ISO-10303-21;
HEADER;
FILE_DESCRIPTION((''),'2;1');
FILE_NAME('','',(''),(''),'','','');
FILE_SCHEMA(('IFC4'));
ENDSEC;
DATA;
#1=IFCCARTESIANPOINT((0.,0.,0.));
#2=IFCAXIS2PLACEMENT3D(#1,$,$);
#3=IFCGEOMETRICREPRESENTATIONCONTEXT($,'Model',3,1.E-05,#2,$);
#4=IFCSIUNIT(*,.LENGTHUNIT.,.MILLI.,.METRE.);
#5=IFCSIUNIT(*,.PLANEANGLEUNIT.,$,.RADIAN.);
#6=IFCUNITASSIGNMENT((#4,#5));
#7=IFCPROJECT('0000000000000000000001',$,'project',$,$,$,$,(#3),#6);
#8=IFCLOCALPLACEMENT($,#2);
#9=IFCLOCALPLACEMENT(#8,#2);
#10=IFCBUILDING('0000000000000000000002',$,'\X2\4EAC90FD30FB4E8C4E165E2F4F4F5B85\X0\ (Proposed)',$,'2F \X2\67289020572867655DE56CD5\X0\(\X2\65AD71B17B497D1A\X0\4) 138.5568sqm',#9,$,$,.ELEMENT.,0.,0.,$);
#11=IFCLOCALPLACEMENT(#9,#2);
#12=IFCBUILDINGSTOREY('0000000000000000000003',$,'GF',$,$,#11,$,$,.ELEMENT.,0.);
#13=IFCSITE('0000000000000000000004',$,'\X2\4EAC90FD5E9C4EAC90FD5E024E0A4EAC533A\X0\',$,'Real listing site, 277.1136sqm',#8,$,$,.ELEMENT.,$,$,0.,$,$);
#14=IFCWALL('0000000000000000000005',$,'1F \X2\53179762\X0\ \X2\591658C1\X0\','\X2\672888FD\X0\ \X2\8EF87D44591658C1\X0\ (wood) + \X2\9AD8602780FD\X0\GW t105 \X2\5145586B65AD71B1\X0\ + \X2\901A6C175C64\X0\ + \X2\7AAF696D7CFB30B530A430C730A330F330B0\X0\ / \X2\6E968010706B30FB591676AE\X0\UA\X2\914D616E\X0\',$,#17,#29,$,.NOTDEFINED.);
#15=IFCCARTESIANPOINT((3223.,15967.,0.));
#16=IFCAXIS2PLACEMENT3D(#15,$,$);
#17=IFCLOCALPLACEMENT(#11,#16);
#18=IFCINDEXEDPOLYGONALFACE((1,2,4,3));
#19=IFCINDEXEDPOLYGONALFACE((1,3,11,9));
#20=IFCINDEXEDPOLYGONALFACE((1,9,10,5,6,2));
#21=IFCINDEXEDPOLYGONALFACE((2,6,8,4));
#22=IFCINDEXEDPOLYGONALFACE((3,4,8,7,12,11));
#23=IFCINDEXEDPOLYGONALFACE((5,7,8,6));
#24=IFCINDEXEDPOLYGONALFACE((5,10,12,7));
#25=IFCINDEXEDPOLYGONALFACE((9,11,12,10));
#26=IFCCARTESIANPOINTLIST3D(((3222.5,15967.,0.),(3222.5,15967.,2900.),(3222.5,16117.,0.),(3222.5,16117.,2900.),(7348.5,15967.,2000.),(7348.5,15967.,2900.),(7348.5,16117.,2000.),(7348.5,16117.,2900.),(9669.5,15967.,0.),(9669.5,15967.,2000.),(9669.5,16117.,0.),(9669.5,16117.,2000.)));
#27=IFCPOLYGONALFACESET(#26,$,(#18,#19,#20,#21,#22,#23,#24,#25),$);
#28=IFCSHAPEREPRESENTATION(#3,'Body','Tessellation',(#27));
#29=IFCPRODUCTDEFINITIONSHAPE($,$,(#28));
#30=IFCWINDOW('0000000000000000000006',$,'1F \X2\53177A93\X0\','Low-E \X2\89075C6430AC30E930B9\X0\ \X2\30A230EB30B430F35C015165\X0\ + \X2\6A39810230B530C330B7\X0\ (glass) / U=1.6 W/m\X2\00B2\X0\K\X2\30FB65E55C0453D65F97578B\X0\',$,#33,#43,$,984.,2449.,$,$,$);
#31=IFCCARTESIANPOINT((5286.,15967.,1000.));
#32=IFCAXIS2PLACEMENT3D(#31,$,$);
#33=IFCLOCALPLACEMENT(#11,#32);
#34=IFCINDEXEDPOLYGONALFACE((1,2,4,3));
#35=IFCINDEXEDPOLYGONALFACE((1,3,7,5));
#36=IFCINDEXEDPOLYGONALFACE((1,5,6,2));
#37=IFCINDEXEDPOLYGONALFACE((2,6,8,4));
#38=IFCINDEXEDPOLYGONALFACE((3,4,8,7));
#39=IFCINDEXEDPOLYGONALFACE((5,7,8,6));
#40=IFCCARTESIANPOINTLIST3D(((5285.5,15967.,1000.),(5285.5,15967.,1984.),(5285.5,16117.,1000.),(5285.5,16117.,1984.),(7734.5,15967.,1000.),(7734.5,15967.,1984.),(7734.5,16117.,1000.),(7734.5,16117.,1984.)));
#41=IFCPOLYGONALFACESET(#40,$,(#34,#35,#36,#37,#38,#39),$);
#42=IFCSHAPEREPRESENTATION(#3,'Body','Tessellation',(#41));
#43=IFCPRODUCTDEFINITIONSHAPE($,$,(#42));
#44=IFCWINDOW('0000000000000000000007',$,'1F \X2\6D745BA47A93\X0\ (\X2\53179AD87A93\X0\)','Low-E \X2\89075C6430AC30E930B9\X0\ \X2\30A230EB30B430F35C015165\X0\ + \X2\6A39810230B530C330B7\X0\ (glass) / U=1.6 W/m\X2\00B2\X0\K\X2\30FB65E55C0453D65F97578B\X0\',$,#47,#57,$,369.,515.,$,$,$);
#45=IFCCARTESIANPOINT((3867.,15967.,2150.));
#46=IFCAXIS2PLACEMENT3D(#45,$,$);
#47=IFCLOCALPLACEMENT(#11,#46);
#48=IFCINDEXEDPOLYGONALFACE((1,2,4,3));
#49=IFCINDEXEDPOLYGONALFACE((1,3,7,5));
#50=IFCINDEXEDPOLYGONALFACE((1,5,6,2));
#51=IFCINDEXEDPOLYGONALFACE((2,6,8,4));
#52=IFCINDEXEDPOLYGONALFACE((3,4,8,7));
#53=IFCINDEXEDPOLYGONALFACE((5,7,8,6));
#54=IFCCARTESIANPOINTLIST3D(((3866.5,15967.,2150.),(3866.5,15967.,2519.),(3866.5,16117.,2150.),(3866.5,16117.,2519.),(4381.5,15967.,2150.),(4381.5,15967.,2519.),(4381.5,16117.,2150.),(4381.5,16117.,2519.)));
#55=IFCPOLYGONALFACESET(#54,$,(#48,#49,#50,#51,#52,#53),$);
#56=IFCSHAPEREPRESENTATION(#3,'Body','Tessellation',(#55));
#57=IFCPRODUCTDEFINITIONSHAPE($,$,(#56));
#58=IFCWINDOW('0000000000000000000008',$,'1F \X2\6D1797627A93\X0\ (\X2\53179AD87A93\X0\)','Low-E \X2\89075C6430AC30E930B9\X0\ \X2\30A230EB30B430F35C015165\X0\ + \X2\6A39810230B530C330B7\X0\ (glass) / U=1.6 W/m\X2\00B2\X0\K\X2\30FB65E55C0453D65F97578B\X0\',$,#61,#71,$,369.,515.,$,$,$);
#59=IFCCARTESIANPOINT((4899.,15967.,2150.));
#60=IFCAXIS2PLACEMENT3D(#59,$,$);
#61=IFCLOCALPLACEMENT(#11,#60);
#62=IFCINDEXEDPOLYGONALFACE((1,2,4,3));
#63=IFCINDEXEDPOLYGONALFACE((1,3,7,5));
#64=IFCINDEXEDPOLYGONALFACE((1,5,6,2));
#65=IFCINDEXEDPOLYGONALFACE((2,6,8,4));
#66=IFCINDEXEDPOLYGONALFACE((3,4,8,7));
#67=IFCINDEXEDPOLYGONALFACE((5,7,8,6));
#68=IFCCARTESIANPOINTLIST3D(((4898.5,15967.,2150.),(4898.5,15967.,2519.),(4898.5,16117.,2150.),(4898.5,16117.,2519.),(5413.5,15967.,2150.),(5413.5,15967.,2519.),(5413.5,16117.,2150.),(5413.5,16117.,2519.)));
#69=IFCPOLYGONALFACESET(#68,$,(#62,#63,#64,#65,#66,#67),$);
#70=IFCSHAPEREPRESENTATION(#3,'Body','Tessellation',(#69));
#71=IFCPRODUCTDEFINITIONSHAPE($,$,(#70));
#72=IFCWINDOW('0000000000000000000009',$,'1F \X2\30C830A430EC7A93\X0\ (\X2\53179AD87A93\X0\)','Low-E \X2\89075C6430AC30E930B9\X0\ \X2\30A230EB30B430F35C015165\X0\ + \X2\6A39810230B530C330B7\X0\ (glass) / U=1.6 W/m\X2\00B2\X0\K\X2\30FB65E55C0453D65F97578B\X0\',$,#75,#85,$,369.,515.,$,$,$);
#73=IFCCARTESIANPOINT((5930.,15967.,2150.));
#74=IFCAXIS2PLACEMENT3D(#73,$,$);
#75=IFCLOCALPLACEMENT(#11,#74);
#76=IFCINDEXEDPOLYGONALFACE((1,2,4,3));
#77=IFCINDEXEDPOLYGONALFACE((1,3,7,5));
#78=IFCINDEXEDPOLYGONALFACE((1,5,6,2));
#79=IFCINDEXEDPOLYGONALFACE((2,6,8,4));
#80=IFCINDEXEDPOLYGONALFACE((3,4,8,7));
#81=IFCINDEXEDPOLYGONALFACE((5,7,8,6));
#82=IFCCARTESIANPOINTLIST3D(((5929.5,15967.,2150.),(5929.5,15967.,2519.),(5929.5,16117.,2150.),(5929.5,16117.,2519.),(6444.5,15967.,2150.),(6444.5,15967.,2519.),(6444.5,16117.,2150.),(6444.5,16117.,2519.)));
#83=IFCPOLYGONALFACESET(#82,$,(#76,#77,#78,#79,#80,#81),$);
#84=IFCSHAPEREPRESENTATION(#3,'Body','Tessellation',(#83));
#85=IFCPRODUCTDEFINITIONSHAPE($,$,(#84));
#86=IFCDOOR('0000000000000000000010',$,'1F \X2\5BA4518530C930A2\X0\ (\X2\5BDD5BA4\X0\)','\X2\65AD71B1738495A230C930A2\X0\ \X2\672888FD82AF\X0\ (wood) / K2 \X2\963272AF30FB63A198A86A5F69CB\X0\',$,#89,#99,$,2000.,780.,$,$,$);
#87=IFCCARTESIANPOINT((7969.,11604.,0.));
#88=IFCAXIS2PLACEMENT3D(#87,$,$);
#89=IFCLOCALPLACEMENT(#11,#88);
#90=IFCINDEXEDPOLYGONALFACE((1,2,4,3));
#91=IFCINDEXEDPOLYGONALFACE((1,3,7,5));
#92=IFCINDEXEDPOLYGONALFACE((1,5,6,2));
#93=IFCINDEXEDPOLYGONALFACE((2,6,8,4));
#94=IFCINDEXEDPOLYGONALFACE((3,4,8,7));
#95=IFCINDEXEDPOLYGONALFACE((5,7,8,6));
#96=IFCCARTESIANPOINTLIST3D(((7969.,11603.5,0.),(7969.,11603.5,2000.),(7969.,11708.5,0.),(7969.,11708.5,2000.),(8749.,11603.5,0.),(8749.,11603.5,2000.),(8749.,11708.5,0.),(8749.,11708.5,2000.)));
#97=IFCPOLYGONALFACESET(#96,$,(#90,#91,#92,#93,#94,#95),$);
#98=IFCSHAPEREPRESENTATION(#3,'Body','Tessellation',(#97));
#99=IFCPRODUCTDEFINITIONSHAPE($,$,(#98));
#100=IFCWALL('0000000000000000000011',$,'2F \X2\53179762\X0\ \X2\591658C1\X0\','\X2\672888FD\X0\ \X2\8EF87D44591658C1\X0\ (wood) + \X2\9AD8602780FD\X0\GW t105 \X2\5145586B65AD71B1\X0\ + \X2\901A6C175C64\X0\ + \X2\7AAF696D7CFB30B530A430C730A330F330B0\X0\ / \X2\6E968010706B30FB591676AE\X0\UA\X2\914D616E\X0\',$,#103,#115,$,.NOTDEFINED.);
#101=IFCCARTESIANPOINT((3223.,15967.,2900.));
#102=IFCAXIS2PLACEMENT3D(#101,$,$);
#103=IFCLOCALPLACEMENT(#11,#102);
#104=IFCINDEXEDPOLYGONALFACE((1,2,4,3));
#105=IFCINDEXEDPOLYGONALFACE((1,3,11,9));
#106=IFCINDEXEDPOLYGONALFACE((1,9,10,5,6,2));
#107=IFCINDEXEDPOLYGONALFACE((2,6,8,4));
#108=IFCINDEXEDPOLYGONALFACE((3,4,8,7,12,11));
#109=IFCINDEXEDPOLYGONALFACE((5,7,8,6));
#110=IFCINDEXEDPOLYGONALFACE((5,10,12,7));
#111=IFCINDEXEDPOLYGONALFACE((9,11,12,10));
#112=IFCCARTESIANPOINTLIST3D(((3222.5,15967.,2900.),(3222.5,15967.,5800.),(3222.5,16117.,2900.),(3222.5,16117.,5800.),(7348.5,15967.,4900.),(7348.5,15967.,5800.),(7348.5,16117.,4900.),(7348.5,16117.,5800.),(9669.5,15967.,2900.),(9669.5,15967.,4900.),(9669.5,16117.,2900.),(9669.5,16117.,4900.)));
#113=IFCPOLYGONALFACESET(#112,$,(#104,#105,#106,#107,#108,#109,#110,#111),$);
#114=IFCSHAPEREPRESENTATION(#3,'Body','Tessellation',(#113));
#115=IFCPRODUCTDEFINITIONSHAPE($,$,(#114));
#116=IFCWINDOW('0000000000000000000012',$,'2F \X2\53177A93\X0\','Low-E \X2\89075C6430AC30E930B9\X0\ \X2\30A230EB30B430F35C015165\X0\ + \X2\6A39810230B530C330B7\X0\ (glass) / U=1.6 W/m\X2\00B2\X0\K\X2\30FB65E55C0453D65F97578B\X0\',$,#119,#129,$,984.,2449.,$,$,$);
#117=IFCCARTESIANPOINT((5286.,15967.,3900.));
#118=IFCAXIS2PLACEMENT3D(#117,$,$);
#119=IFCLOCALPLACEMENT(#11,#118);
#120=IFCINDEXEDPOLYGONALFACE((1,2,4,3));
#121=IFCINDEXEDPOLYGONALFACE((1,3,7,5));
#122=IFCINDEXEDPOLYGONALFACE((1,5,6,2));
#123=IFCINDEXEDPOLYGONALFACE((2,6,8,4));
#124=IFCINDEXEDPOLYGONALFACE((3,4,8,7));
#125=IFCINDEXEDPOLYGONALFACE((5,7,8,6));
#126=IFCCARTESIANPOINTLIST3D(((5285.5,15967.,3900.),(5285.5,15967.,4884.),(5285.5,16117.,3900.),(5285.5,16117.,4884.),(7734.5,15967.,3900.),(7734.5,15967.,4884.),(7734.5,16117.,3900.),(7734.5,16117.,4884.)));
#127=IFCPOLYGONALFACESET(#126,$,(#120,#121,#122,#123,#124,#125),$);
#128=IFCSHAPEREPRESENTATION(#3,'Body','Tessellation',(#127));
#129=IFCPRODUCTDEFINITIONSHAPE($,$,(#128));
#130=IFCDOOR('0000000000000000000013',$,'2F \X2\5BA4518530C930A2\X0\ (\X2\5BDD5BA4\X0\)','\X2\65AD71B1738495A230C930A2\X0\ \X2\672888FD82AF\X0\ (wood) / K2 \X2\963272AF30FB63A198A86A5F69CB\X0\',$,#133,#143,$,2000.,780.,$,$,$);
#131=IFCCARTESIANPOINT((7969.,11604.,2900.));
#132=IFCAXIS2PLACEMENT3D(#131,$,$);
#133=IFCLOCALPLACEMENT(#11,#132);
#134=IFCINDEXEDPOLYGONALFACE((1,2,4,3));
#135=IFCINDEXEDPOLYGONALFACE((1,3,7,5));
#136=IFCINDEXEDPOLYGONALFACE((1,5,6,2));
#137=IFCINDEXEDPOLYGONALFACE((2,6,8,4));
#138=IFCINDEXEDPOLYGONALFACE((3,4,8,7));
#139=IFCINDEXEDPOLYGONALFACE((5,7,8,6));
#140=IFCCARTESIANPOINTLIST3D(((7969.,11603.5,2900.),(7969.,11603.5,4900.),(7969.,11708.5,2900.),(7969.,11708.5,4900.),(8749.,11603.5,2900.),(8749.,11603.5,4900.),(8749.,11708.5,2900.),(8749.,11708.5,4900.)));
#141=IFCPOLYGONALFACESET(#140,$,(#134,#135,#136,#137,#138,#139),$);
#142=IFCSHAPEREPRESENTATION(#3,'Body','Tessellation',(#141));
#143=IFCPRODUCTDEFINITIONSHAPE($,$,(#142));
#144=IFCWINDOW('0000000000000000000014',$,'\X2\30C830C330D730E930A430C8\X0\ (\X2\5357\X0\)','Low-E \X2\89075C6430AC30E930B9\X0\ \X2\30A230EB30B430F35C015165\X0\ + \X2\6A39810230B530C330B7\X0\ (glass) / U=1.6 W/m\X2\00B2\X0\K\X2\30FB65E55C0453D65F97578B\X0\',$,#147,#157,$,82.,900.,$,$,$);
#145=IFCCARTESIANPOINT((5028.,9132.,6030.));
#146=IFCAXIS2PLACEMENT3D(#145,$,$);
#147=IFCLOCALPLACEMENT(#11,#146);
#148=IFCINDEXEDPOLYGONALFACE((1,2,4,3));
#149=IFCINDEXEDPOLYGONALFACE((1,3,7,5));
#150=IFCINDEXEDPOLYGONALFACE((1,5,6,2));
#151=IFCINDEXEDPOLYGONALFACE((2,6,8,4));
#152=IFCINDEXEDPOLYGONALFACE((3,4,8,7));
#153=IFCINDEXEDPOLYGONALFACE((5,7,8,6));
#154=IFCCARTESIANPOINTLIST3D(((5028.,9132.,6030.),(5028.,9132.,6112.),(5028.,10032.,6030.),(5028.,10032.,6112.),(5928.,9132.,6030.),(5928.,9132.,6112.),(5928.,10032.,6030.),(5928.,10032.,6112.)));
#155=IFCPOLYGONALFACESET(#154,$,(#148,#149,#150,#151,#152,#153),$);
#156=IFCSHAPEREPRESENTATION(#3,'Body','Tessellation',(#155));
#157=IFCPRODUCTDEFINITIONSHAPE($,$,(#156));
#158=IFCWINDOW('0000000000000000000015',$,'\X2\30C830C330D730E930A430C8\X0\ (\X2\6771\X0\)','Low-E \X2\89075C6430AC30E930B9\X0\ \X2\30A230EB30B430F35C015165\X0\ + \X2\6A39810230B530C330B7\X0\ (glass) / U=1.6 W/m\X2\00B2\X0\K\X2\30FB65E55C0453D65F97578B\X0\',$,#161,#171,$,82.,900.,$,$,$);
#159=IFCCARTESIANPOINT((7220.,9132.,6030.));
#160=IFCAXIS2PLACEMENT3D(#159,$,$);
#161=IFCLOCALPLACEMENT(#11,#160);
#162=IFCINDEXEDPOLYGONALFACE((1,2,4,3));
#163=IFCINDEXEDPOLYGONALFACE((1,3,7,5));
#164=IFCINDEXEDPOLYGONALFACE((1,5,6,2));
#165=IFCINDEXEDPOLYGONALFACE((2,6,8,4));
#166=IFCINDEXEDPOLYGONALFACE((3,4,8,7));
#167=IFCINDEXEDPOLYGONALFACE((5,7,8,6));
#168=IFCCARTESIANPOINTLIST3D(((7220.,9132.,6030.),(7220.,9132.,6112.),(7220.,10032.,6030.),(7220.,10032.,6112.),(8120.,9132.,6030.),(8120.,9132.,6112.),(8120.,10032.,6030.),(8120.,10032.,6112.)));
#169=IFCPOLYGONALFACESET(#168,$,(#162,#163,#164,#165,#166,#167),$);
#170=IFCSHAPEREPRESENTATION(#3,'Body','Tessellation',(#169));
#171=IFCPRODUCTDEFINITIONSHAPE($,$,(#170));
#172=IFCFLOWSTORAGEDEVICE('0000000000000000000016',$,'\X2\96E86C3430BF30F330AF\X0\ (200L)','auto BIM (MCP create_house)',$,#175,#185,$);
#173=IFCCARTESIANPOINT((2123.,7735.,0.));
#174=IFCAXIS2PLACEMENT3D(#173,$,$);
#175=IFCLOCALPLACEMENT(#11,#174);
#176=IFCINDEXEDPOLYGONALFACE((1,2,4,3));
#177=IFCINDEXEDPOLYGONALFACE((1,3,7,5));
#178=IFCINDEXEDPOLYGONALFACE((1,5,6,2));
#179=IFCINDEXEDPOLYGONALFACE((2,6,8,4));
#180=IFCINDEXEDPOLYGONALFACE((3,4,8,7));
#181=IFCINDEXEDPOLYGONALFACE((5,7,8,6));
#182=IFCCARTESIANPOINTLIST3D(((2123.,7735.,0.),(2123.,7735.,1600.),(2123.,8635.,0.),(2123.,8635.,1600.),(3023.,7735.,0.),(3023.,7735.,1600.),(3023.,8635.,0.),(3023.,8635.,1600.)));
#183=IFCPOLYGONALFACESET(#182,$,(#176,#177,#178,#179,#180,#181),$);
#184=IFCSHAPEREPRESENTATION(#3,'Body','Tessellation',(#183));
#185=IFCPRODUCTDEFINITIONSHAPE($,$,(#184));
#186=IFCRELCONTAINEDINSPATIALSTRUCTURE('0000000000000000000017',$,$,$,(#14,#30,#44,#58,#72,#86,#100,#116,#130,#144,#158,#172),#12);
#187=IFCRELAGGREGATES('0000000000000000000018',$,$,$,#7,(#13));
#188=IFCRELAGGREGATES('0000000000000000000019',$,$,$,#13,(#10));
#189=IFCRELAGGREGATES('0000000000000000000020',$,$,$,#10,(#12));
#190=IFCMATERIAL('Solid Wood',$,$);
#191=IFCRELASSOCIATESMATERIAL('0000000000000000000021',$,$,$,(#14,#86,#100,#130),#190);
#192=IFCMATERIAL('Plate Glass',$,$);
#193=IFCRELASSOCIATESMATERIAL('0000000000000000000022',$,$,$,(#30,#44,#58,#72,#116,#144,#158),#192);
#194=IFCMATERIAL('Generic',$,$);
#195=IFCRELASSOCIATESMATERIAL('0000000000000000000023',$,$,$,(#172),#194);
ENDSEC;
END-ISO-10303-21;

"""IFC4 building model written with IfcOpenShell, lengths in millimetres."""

from ifc_helpers import new_model, si_unit, frame, frame_2d, origin, place, context, project, spatial, rectangle, extrude, material, element, fill, save


model = new_model("IFC4")

# Units and contexts
model_context = context("Model", 3, precision=1e-05, world=origin())
ifc_project = project(units=[si_unit("LENGTHUNIT", "METRE", prefix="MILLI"), si_unit("PLANEANGLEUNIT", "RADIAN")], contexts=[model_context])

# Site, building, storey
site_placement = place(None, origin())
site = spatial("IfcSite", under=ifc_project, at=site_placement, Name="京都府京都市上京区", ObjectType="Real listing site, 277.1136sqm", CompositionType="ELEMENT", RefElevation=0.0)
building_placement = place(site_placement, origin())
building = spatial("IfcBuilding", under=site, at=building_placement, Name="京都・二世帯住宅 (Proposed)", ObjectType="2F 木造在来工法(断熱等級4) 138.5568sqm", CompositionType="ELEMENT", ElevationOfRefHeight=0.0, ElevationOfTerrain=0.0)
storey_placement = place(building_placement, origin())
storey = spatial("IfcBuildingStorey", under=building, at=storey_placement, Name="GF", CompositionType="ELEMENT", Elevation=0.0)

# Wall, openings, windows
ifc_material_1 = material(Name="Solid Wood")
wall_1_placement = place(storey_placement, frame((3223.0, 15967.0, 0.0)))
wall_1 = element("IfcWall", 1, at=wall_1_placement, inside=storey, material=ifc_material_1, Name="1F 北面 外壁", Description="木製 軸組外壁 (wood) + 高性能GW t105 充填断熱 + 通気層 + 窯業系サイディング / 準耐火・外皮UA配慮", PredefinedType="NOTDEFINED", context=model_context, shape_type="SweptSolid", body=[
    extrude(rectangle(XDim=6447.0, YDim=150.0, at=frame_2d((3223.0, 75.0))), frame((3223.0, 15967.0, 0.0)), (0.0, 0.0, 1.0), 2900.0),
])
opening_1_placement = place(storey_placement, frame((5286.0, 15967.0, 1000.0)))
opening_1 = element("IfcOpeningElement", 2, at=opening_1_placement, cuts=wall_1, PredefinedType="NOTDEFINED", context=model_context, shape_type="SweptSolid", body=[
    extrude(rectangle(XDim=2449.0, YDim=150.0, at=frame_2d((1224.0, 75.0))), frame((5286.0, 15967.0, 1000.0)), (0.0, 0.0, 1.0), 984.0),
])
opening_2_placement = place(storey_placement, frame((3867.0, 15967.0, 2150.0)))
opening_2 = element("IfcOpeningElement", 3, at=opening_2_placement, cuts=wall_1, PredefinedType="NOTDEFINED", context=model_context, shape_type="SweptSolid", body=[
    extrude(rectangle(XDim=515.0, YDim=150.0, at=frame_2d((257.0, 75.0))), frame((3867.0, 15967.0, 2150.0)), (0.0, 0.0, 1.0), 369.0),
])
opening_3_placement = place(storey_placement, frame((4899.0, 15967.0, 2150.0)))
opening_3 = element("IfcOpeningElement", 4, at=opening_3_placement, cuts=wall_1, PredefinedType="NOTDEFINED", context=model_context, shape_type="SweptSolid", body=[
    extrude(rectangle(XDim=515.0, YDim=150.0, at=frame_2d((257.0, 75.0))), frame((4899.0, 15967.0, 2150.0)), (0.0, 0.0, 1.0), 369.0),
])
opening_4_placement = place(storey_placement, frame((5930.0, 15967.0, 2150.0)))
opening_4 = element("IfcOpeningElement", 5, at=opening_4_placement, cuts=wall_1, PredefinedType="NOTDEFINED", context=model_context, shape_type="SweptSolid", body=[
    extrude(rectangle(XDim=515.0, YDim=150.0, at=frame_2d((257.0, 75.0))), frame((5930.0, 15967.0, 2150.0)), (0.0, 0.0, 1.0), 369.0),
])
ifc_material_2 = material(Name="Plate Glass")
window_1_placement = place(storey_placement, frame((5286.0, 15967.0, 1000.0)))
window_1 = element("IfcWindow", 6, at=window_1_placement, inside=storey, material=ifc_material_2, Name="1F 北窓", Description="Low-E 複層ガラス アルゴン封入 + 樹脂サッシ (glass) / U=1.6 W/m²K・日射取得型", OverallHeight=984.0, OverallWidth=2449.0, context=model_context, shape_type="SweptSolid", body=[
    extrude(rectangle(XDim=2449.0, YDim=150.0, at=frame_2d((1224.0, 75.0))), frame((5286.0, 15967.0, 1000.0)), (0.0, 0.0, 1.0), 984.0),
])
fill(opening_1, window_1)
window_2_placement = place(storey_placement, frame((3867.0, 15967.0, 2150.0)))
window_2 = element("IfcWindow", 7, at=window_2_placement, inside=storey, material=ifc_material_2, Name="1F 浴室窓 (北高窓)", Description="Low-E 複層ガラス アルゴン封入 + 樹脂サッシ (glass) / U=1.6 W/m²K・日射取得型", OverallHeight=369.0, OverallWidth=515.0, context=model_context, shape_type="SweptSolid", body=[
    extrude(rectangle(XDim=515.0, YDim=150.0, at=frame_2d((257.0, 75.0))), frame((3867.0, 15967.0, 2150.0)), (0.0, 0.0, 1.0), 369.0),
])
fill(opening_2, window_2)
window_3_placement = place(storey_placement, frame((4899.0, 15967.0, 2150.0)))
window_3 = element("IfcWindow", 8, at=window_3_placement, inside=storey, material=ifc_material_2, Name="1F 洗面窓 (北高窓)", Description="Low-E 複層ガラス アルゴン封入 + 樹脂サッシ (glass) / U=1.6 W/m²K・日射取得型", OverallHeight=369.0, OverallWidth=515.0, context=model_context, shape_type="SweptSolid", body=[
    extrude(rectangle(XDim=515.0, YDim=150.0, at=frame_2d((257.0, 75.0))), frame((4899.0, 15967.0, 2150.0)), (0.0, 0.0, 1.0), 369.0),
])
fill(opening_3, window_3)
window_4_placement = place(storey_placement, frame((5930.0, 15967.0, 2150.0)))
window_4 = element("IfcWindow", 9, at=window_4_placement, inside=storey, material=ifc_material_2, Name="1F トイレ窓 (北高窓)", Description="Low-E 複層ガラス アルゴン封入 + 樹脂サッシ (glass) / U=1.6 W/m²K・日射取得型", OverallHeight=369.0, OverallWidth=515.0, context=model_context, shape_type="SweptSolid", body=[
    extrude(rectangle(XDim=515.0, YDim=150.0, at=frame_2d((257.0, 75.0))), frame((5930.0, 15967.0, 2150.0)), (0.0, 0.0, 1.0), 369.0),
])
fill(opening_4, window_4)

# Door
door_1_placement = place(storey_placement, frame((7969.0, 11604.0, 0.0)))
element("IfcDoor", 10, at=door_1_placement, inside=storey, material=ifc_material_1, Name="1F 室内ドア (寝室)", Description="断熱玄関ドア 木製芯 (wood) / K2 防犯・採風機構", OverallHeight=2000.0, OverallWidth=780.0, context=model_context, shape_type="SweptSolid", body=[
    extrude(rectangle(XDim=780.0, YDim=105.0, at=frame_2d((390.0, 52.0))), frame((7969.0, 11604.0, 0.0)), (0.0, 0.0, 1.0), 2000.0),
])

# Wall, opening, window
wall_2_placement = place(storey_placement, frame((3223.0, 15967.0, 2900.0)))
wall_2 = element("IfcWall", 11, at=wall_2_placement, inside=storey, material=ifc_material_1, Name="2F 北面 外壁", Description="木製 軸組外壁 (wood) + 高性能GW t105 充填断熱 + 通気層 + 窯業系サイディング / 準耐火・外皮UA配慮", PredefinedType="NOTDEFINED", context=model_context, shape_type="SweptSolid", body=[
    extrude(rectangle(XDim=6447.0, YDim=150.0, at=frame_2d((3223.0, 75.0))), frame((3223.0, 15967.0, 2900.0)), (0.0, 0.0, 1.0), 2900.0),
])
opening_5_placement = place(storey_placement, frame((5286.0, 15967.0, 3900.0)))
opening_5 = element("IfcOpeningElement", 12, at=opening_5_placement, cuts=wall_2, PredefinedType="NOTDEFINED", context=model_context, shape_type="SweptSolid", body=[
    extrude(rectangle(XDim=2449.0, YDim=150.0, at=frame_2d((1224.0, 75.0))), frame((5286.0, 15967.0, 3900.0)), (0.0, 0.0, 1.0), 984.0),
])
window_5_placement = place(storey_placement, frame((5286.0, 15967.0, 3900.0)))
window_5 = element("IfcWindow", 13, at=window_5_placement, inside=storey, material=ifc_material_2, Name="2F 北窓", Description="Low-E 複層ガラス アルゴン封入 + 樹脂サッシ (glass) / U=1.6 W/m²K・日射取得型", OverallHeight=984.0, OverallWidth=2449.0, context=model_context, shape_type="SweptSolid", body=[
    extrude(rectangle(XDim=2449.0, YDim=150.0, at=frame_2d((1224.0, 75.0))), frame((5286.0, 15967.0, 3900.0)), (0.0, 0.0, 1.0), 984.0),
])
fill(opening_5, window_5)

# Door
door_2_placement = place(storey_placement, frame((7969.0, 11604.0, 2900.0)))
element("IfcDoor", 14, at=door_2_placement, inside=storey, material=ifc_material_1, Name="2F 室内ドア (寝室)", Description="断熱玄関ドア 木製芯 (wood) / K2 防犯・採風機構", OverallHeight=2000.0, OverallWidth=780.0, context=model_context, shape_type="SweptSolid", body=[
    extrude(rectangle(XDim=780.0, YDim=105.0, at=frame_2d((390.0, 52.0))), frame((7969.0, 11604.0, 2900.0)), (0.0, 0.0, 1.0), 2000.0),
])

# Windows
window_6_placement = place(storey_placement, frame((5028.0, 9132.0, 6030.0)))
element("IfcWindow", 15, at=window_6_placement, inside=storey, material=ifc_material_2, Name="トップライト (南)", Description="Low-E 複層ガラス アルゴン封入 + 樹脂サッシ (glass) / U=1.6 W/m²K・日射取得型", OverallHeight=82.0, OverallWidth=900.0, context=model_context, shape_type="SweptSolid", body=[
    extrude(rectangle(XDim=900.0, YDim=900.0, at=frame_2d((450.0, 450.0))), frame((5028.0, 9132.0, 6030.0)), (0.0, 0.0, 1.0), 82.0),
])
window_7_placement = place(storey_placement, frame((7220.0, 9132.0, 6030.0)))
element("IfcWindow", 16, at=window_7_placement, inside=storey, material=ifc_material_2, Name="トップライト (東)", Description="Low-E 複層ガラス アルゴン封入 + 樹脂サッシ (glass) / U=1.6 W/m²K・日射取得型", OverallHeight=82.0, OverallWidth=900.0, context=model_context, shape_type="SweptSolid", body=[
    extrude(rectangle(XDim=900.0, YDim=900.0, at=frame_2d((450.0, 450.0))), frame((7220.0, 9132.0, 6030.0)), (0.0, 0.0, 1.0), 82.0),
])

# Flow storage device
ifc_material_3 = material(Name="Generic")
flow_storage_device_placement = place(storey_placement, frame((2123.0, 7735.0, 0.0)))
element("IfcFlowStorageDevice", 17, at=flow_storage_device_placement, inside=storey, material=ifc_material_3, Name="雨水タンク (200L)", Description="auto BIM (MCP create_house)", context=model_context, shape_type="SweptSolid", body=[
    extrude(rectangle(XDim=900.0, YDim=900.0, at=frame_2d((450.0, 450.0))), frame((2123.0, 7735.0, 0.0)), (0.0, 0.0, 1.0), 1600.0),
])

save(model, "model.ifc")
